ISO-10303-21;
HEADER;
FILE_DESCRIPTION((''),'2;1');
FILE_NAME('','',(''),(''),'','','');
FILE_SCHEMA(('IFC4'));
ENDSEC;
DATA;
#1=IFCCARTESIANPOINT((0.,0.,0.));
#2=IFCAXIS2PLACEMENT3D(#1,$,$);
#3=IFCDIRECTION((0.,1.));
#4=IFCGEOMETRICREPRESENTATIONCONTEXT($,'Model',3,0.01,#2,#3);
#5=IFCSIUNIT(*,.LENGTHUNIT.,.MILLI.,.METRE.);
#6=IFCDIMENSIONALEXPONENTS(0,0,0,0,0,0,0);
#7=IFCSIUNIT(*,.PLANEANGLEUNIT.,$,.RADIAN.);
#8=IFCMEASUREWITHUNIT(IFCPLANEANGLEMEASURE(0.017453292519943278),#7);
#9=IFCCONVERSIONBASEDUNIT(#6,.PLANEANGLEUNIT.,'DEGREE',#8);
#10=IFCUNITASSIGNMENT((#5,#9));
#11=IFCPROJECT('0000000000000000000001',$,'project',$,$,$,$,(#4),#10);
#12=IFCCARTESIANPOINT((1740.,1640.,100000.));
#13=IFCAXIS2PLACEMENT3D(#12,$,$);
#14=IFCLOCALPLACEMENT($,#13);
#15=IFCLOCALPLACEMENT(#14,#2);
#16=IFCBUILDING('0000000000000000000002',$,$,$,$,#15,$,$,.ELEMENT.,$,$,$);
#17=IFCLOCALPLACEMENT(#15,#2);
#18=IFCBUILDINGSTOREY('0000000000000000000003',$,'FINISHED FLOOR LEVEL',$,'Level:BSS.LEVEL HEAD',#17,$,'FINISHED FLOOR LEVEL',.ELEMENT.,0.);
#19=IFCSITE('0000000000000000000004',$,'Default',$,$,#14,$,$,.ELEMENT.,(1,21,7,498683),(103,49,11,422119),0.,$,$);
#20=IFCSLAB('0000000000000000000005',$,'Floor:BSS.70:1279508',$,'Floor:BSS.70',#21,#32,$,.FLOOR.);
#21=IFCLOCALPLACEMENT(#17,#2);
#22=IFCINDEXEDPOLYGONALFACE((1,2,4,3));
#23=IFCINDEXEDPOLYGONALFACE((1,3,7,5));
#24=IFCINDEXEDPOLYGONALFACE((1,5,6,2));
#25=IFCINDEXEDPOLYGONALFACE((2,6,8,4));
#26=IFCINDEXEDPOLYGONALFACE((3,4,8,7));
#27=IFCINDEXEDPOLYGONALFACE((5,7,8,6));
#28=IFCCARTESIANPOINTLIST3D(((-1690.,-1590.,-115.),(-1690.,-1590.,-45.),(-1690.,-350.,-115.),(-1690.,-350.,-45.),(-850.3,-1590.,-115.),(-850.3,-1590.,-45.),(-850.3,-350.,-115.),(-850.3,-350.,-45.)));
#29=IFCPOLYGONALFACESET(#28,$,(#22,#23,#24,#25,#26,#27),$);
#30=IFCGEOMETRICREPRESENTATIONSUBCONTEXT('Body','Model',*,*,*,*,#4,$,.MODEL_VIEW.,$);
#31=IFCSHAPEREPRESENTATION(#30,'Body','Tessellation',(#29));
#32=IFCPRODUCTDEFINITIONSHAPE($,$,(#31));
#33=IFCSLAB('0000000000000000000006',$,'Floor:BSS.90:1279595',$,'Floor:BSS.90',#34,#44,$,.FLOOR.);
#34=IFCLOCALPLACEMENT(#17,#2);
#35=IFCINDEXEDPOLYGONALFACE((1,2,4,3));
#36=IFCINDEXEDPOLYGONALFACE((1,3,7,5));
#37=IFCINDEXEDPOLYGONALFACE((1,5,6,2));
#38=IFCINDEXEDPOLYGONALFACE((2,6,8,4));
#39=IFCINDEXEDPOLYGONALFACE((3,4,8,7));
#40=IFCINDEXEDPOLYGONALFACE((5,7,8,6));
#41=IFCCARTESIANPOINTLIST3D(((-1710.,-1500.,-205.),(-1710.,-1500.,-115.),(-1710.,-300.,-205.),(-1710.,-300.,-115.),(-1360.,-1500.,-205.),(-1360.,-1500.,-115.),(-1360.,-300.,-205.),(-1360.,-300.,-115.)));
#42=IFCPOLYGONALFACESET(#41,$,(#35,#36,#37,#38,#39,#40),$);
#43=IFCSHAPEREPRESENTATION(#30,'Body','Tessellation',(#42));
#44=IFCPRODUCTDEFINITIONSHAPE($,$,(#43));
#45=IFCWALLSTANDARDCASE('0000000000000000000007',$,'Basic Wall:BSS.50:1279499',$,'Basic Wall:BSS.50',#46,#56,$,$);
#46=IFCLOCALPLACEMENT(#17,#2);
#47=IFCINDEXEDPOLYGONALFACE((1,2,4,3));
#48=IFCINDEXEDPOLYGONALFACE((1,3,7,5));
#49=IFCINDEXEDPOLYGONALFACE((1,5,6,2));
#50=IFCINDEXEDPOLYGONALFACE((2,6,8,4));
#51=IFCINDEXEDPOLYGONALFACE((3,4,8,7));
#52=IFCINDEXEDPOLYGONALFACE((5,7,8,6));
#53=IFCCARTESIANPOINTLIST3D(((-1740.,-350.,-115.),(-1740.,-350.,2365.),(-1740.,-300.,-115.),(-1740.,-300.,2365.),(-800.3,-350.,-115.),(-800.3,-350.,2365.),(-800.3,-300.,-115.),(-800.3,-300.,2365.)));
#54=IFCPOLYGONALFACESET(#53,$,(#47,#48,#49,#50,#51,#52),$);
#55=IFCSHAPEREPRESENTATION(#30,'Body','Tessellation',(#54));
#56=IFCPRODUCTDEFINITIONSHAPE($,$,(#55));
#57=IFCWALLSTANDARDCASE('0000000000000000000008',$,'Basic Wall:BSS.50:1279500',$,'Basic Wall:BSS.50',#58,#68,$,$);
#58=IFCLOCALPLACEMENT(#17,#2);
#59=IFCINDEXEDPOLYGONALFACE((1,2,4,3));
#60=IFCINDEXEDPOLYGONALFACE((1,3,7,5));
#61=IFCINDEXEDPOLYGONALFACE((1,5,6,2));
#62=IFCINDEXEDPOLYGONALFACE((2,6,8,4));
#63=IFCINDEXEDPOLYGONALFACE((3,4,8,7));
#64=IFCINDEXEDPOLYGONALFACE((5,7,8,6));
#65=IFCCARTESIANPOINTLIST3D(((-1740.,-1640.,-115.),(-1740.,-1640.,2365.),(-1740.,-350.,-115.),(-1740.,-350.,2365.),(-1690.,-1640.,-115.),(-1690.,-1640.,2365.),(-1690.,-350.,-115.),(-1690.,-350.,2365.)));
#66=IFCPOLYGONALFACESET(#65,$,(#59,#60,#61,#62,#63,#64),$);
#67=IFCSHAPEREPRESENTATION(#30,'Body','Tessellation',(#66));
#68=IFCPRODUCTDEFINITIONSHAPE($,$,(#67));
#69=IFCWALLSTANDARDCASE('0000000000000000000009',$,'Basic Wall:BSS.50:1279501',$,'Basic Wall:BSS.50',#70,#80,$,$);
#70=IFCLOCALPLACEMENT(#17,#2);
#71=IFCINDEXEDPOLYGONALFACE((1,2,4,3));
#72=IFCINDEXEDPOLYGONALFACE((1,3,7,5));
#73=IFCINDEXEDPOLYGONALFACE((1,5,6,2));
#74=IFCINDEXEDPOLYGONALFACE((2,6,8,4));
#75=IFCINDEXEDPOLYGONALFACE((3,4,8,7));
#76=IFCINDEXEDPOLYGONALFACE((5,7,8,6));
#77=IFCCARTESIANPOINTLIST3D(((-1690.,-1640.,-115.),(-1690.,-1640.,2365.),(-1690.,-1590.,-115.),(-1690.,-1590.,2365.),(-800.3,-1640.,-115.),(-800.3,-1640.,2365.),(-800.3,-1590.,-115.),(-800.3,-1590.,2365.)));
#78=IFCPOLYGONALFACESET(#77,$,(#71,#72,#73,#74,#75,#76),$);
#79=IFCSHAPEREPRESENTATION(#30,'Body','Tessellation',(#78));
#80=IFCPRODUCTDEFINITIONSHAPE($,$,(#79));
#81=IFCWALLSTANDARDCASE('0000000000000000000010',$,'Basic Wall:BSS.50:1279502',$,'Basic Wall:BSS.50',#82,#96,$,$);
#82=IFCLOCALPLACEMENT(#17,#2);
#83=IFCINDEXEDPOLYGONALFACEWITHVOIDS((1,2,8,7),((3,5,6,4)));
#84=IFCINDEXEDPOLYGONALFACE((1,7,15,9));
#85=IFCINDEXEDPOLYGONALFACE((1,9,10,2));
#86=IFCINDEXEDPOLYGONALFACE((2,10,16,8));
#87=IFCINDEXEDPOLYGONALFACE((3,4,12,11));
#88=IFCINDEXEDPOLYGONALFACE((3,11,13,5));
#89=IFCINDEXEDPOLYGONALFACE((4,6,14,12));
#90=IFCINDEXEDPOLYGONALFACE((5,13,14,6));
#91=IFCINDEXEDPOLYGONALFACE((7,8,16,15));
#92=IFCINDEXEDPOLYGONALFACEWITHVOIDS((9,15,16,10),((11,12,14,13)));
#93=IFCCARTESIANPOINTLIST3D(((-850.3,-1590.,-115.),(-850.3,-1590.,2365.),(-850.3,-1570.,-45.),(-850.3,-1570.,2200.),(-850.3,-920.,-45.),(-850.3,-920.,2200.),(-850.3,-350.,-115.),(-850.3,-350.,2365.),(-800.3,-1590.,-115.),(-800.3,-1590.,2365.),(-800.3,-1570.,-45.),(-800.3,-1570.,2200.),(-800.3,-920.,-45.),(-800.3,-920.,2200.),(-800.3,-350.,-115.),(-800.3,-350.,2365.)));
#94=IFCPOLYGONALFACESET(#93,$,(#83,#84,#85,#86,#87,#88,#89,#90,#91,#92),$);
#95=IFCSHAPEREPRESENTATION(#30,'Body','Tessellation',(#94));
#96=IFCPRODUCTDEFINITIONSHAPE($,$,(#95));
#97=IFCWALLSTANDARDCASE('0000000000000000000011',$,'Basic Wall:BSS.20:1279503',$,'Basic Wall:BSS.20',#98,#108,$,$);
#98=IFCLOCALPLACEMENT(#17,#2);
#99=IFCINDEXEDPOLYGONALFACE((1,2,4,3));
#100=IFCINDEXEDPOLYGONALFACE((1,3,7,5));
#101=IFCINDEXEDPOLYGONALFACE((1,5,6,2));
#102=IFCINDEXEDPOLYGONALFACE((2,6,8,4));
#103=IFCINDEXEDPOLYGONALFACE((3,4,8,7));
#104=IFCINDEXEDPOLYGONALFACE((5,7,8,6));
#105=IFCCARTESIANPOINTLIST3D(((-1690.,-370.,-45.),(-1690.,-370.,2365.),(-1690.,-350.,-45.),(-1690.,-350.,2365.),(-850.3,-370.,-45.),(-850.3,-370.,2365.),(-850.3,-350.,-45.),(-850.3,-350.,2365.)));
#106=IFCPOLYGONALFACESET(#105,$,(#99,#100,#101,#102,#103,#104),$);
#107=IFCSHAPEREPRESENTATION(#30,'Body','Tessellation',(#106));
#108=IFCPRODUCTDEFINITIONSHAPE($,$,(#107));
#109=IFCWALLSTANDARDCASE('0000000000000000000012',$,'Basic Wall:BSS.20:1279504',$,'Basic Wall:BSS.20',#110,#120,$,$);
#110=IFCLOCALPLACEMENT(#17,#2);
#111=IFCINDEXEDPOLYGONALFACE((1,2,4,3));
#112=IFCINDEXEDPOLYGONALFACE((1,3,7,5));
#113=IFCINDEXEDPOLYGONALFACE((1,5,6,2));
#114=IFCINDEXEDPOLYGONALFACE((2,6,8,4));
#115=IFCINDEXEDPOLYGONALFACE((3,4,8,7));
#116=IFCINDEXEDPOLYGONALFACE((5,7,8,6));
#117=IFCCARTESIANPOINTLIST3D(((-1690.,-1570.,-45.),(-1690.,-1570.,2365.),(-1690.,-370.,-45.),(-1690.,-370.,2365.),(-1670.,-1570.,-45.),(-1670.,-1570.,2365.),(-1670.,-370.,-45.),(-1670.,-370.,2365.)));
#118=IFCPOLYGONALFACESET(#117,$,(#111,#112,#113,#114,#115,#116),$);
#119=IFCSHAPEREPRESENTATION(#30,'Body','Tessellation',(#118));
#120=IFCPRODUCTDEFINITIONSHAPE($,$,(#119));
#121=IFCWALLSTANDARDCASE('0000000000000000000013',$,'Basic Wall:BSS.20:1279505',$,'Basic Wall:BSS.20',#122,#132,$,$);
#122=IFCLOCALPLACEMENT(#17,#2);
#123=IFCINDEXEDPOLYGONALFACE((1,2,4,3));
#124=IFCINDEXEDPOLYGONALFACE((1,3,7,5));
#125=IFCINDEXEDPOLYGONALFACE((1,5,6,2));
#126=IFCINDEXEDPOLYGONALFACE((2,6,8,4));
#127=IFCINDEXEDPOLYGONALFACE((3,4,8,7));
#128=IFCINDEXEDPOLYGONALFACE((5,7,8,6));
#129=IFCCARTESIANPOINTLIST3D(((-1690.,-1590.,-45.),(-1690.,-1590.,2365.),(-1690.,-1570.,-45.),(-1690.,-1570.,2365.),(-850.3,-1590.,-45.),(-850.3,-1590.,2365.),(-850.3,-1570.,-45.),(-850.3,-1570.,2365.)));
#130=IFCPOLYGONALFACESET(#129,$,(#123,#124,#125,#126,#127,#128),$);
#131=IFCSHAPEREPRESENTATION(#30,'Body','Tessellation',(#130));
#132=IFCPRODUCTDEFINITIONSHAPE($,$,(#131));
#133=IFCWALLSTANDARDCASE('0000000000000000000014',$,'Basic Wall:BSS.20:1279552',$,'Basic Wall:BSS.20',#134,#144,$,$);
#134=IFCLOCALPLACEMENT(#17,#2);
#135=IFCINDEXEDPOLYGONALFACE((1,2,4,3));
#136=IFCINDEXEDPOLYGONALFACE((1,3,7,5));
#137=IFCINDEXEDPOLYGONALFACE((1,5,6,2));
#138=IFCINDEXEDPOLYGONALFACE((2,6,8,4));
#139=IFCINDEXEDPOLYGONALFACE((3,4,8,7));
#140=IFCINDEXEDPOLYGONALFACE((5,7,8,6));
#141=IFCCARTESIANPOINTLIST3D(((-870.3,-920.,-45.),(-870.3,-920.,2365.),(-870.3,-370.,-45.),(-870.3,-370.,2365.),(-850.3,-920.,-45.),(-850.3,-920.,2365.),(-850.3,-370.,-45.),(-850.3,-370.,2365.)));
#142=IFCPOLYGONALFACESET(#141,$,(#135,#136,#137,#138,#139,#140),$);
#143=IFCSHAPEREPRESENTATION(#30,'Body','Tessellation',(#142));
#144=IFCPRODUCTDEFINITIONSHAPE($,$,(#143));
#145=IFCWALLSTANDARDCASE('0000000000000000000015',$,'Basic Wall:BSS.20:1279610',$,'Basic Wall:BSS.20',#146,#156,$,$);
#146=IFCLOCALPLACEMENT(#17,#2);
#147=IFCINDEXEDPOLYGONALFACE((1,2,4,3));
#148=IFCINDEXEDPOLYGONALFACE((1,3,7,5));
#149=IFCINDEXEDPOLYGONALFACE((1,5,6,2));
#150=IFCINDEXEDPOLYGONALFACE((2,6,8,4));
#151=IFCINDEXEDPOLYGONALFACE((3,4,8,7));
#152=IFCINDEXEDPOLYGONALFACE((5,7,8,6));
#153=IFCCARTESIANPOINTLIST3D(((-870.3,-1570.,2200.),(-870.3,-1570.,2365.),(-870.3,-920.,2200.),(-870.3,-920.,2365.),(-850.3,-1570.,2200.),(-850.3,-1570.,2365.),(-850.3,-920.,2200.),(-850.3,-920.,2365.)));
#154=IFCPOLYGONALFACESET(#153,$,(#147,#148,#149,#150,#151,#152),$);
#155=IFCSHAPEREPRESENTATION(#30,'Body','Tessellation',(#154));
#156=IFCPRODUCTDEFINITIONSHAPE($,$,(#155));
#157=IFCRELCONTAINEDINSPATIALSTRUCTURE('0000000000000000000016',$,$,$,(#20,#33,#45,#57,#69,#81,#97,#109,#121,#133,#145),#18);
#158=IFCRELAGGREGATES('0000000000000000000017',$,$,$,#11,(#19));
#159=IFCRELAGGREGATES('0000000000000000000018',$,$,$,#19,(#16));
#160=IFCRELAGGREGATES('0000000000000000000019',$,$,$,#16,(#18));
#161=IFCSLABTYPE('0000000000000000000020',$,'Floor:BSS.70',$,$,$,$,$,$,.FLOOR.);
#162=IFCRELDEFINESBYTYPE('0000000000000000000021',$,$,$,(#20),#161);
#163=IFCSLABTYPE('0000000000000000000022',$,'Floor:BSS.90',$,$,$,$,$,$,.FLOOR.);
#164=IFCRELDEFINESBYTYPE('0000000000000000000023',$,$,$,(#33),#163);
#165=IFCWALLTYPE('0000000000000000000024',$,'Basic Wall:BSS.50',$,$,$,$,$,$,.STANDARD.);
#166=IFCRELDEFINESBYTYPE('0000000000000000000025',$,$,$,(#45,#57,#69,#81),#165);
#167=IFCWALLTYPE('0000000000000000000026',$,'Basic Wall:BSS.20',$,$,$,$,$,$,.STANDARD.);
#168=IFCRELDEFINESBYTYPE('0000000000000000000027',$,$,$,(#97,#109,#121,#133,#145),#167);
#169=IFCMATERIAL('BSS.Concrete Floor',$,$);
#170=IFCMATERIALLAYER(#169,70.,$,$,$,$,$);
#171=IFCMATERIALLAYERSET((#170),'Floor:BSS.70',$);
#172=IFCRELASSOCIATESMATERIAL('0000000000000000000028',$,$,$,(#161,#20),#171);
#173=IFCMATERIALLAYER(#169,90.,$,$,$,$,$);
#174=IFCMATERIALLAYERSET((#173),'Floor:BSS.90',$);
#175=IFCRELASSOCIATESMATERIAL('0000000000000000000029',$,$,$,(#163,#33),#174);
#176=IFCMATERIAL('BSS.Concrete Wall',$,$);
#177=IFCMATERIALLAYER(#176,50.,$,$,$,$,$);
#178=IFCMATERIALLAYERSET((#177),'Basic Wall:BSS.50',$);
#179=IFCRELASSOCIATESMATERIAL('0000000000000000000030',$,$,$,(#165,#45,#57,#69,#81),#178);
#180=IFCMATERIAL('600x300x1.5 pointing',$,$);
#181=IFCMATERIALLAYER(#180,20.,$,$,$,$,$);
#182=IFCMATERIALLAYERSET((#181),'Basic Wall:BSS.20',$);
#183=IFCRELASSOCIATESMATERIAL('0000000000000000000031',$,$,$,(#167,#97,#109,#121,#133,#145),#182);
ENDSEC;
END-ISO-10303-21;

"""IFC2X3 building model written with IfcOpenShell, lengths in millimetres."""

from ifc_helpers import new_model, entity, si_unit, converted_unit, direction, frame, frame_2d, origin, place, context, subcontext, project, spatial, polyline, rectangle, extrude, clip, halfspace, bounded_halfspace, material, layer, layer_set, layer_usage, type_object, element, save


model = new_model("IFC2X3")

# Units and contexts
model_context = context("Model", 3, precision=0.01, world=origin(), true_north=direction((0.0, 1.0)))
body_context = subcontext(model_context, "Body", "Model", "MODEL_VIEW")
ifc_project = project(units=[si_unit("LENGTHUNIT", "METRE", prefix="MILLI"), converted_unit("PLANEANGLEUNIT", "DEGREE", entity("IfcPlaneAngleMeasure", 0.017453292519943278), si_unit("PLANEANGLEUNIT", "RADIAN"), dimensions=[0, 0, 0, 0, 0, 0, 0])], contexts=[model_context])

# Site, building, storey
site_placement = place(None, frame((1740.0, 1640.0, 100000.0)))
site = spatial("IfcSite", under=ifc_project, at=site_placement, Name="Default", CompositionType="ELEMENT", RefLatitude=(1, 21, 7, 498683), RefLongitude=(103, 49, 11, 422119), RefElevation=0.0)
building_placement = place(site_placement, origin())
building = spatial("IfcBuilding", under=site, at=building_placement, CompositionType="ELEMENT")
storey_placement = place(building_placement, origin())
storey = spatial("IfcBuildingStorey", under=building, at=storey_placement, Name="FINISHED FLOOR LEVEL", ObjectType="Level:BSS.LEVEL HEAD", LongName="FINISHED FLOOR LEVEL", CompositionType="ELEMENT", Elevation=0.0)

# Slabs
ifc_material_1 = material(Name="BSS.Concrete Floor")
ifc_layer_1 = layer(ifc_material_1, 70.0)
ifc_layer_set_1 = layer_set([ifc_layer_1], Name="Floor:BSS.70")
ifc_layer_usage_1 = layer_usage(ifc_layer_set_1, "AXIS3", "POSITIVE", 0.0)
slab_type_1 = type_object("IfcSlabType", Name="Floor:BSS.70", PredefinedType="FLOOR", material=ifc_layer_set_1)
slab_1_placement = place(storey_placement, origin())
element("IfcSlab", 1, at=slab_1_placement, inside=storey, type_object=slab_type_1, material=ifc_layer_usage_1, Name="Floor:BSS.70:1279508", ObjectType="Floor:BSS.70", PredefinedType="FLOOR", context=body_context, shape_type="SweptSolid", body=[
    extrude(rectangle(XDim=1240.0, YDim=839.7, at=frame_2d((0.0, 0.0), x_axis=(1.0, 0.0))), frame((-1270.1, -970.0, -45.0), z_axis=(0.0, 0.0, -1.0), x_axis=(0.0, 1.0, 0.0)), (0.0, 0.0, 1.0), 70.0),
])
ifc_material_2 = material(Name="600x300x1.5 pointing")
ifc_layer_2 = layer(ifc_material_1, 90.0)
ifc_layer_set_2 = layer_set([ifc_layer_2], Name="Floor:BSS.90")
ifc_layer_usage_2 = layer_usage(ifc_layer_set_2, "AXIS3", "POSITIVE", 0.0)
slab_type_2 = type_object("IfcSlabType", Name="Floor:BSS.90", PredefinedType="FLOOR", material=ifc_layer_set_2)
slab_2_placement = place(storey_placement, origin())
element("IfcSlab", 2, at=slab_2_placement, inside=storey, type_object=slab_type_2, material=ifc_layer_usage_2, Name="Floor:BSS.90:1279595", ObjectType="Floor:BSS.90", PredefinedType="FLOOR", context=body_context, shape_type="SweptSolid", body=[
    extrude(rectangle(XDim=1200.0, YDim=350.0, at=frame_2d((0.0, 0.0), x_axis=(1.0, 0.0))), frame((-1535.0, -900.0, -115.0), z_axis=(0.0, 0.0, -1.0), x_axis=(0.0, 1.0, 0.0)), (0.0, 0.0, 1.0), 90.0),
])

# Walls
ifc_material_3 = material(Name="BSS.Concrete Wall")
ifc_layer_3 = layer(ifc_material_3, 50.0)
ifc_layer_set_3 = layer_set([ifc_layer_3], Name="Basic Wall:BSS.50")
ifc_layer_usage_3 = layer_usage(ifc_layer_set_3, "AXIS2", "POSITIVE", -25.0)
wall_type_1 = type_object("IfcWallType", Name="Basic Wall:BSS.50", PredefinedType="STANDARD", material=ifc_layer_set_3)
wall_1_placement = place(storey_placement, frame((-800.3, -325.0, -115.0), z_axis=(0.0, 0.0, 1.0), x_axis=(-1.0, 0.0, 0.0)))
element("IfcWallStandardCase", 3, at=wall_1_placement, inside=storey, type_object=wall_type_1, material=ifc_layer_usage_3, Name="Basic Wall:BSS.50:1279499", ObjectType="Basic Wall:BSS.50", context=body_context, shape_type="Clipping", body=[
    clip(extrude(rectangle(XDim=939.7, YDim=50.0, at=frame_2d((469.9, 0.0), x_axis=(-1.0, 0.0))), origin(), (0.0, 0.0, 1.0), 2480.0), bounded_halfspace(frame((0.0, -25.0, 2480.0), z_axis=(0.0, 0.0, -1.0), x_axis=(0.0, 1.0, 0.0)), True, frame((0.0, -25.0, 2480.0)), polyline([(0.0, 0.0), (939.7, 0.0), (939.7, 50.0), (889.7, 50.0), (50.0, 50.0), (0.0, 50.0), (0.0, 0.0)]))),
])
ifc_layer_usage_4 = layer_usage(ifc_layer_set_3, "AXIS2", "NEGATIVE", 25.0)
wall_2_placement = place(storey_placement, frame((-1715.0, -350.0, -115.0), z_axis=(0.0, 0.0, 1.0), x_axis=(0.0, -1.0, 0.0)))
element("IfcWallStandardCase", 4, at=wall_2_placement, inside=storey, type_object=wall_type_1, material=ifc_layer_usage_4, Name="Basic Wall:BSS.50:1279500", ObjectType="Basic Wall:BSS.50", context=body_context, shape_type="Clipping", body=[
    clip(extrude(rectangle(XDim=1290.0, YDim=50.0, at=frame_2d((645.0, 0.0), x_axis=(-1.0, 0.0))), origin(), (0.0, 0.0, 1.0), 2480.0), bounded_halfspace(frame((0.0, -25.0, 2480.0), z_axis=(0.0, 0.0, -1.0), x_axis=(1.0, 0.0, 0.0)), True, frame((0.0, -25.0, 2480.0)), polyline([(0.0, 0.0), (1290.0, 0.0), (1290.0, 50.0), (1240.0, 50.0), (0.0, 50.0), (0.0, 0.0)]))),
])
ifc_layer_usage_5 = layer_usage(ifc_layer_set_3, "AXIS2", "NEGATIVE", 25.0)
wall_3_placement = place(storey_placement, frame((-1690.0, -1615.0, -115.0)))
element("IfcWallStandardCase", 5, at=wall_3_placement, inside=storey, type_object=wall_type_1, material=ifc_layer_usage_5, Name="Basic Wall:BSS.50:1279501", ObjectType="Basic Wall:BSS.50", context=body_context, shape_type="Clipping", body=[
    clip(extrude(rectangle(XDim=889.7, YDim=50.0, at=frame_2d((444.9, 0.0), x_axis=(-1.0, 0.0))), origin(), (0.0, 0.0, 1.0), 2480.0), bounded_halfspace(frame((0.0, -25.0, 2480.0), z_axis=(0.0, 0.0, -1.0), x_axis=(0.0, -1.0, 0.0)), True, frame((0.0, -25.0, 2480.0)), polyline([(0.0, 0.0), (889.7, 0.0), (889.7, 50.0), (839.7, 50.0), (0.0, 50.0), (0.0, 0.0)]))),
])

# Wall, opening
ifc_layer_usage_6 = layer_usage(ifc_layer_set_3, "AXIS2", "POSITIVE", -25.0)
wall_4_placement = place(storey_placement, frame((-825.3, -1590.0, -115.0), z_axis=(0.0, 0.0, 1.0), x_axis=(0.0, 1.0, 0.0)))
wall_4 = element("IfcWallStandardCase", 6, at=wall_4_placement, inside=storey, type_object=wall_type_1, material=ifc_layer_usage_6, Name="Basic Wall:BSS.50:1279502", ObjectType="Basic Wall:BSS.50", context=body_context, shape_type="Clipping", body=[
    clip(extrude(rectangle(XDim=1240.0, YDim=50.0, at=frame_2d((620.0, 0.0), x_axis=(-1.0, 0.0))), origin(), (0.0, 0.0, 1.0), 2480.0), bounded_halfspace(frame((0.0, -25.0, 2480.0), z_axis=(0.0, 0.0, -1.0), x_axis=(-1.0, 0.0, 0.0)), True, frame((0.0, -25.0, 2480.0)), polyline([(0.0, 0.0), (1240.0, 0.0), (1240.0, 50.0), (1220.0, 50.0), (0.0, 50.0), (0.0, 0.0)]))),
])
opening_placement = place(wall_4_placement, frame((1590.0, -825.3, 115.0), z_axis=(0.0, 0.0, 1.0), x_axis=(0.0, -1.0, 0.0)))
element("IfcOpeningElement", 7, at=opening_placement, cuts=wall_4, ObjectType="Opening", context=body_context, shape_type="SweptSolid", body=[
    extrude(rectangle(XDim=2245.0, YDim=650.0, at=frame_2d((0.0, 0.0), x_axis=(0.0, 1.0))), frame((673.7, -1245.0, 1077.5), z_axis=(-1.0, 0.0, 0.0), x_axis=(0.0, 1.0, 0.0)), (0.0, 0.0, 1.0), 3048.0),
])

# Walls
ifc_layer_4 = layer(ifc_material_2, 20.0)
ifc_layer_set_4 = layer_set([ifc_layer_4], Name="Basic Wall:BSS.20")
ifc_layer_usage_7 = layer_usage(ifc_layer_set_4, "AXIS2", "POSITIVE", -10.0)
wall_type_2 = type_object("IfcWallType", Name="Basic Wall:BSS.20", PredefinedType="STANDARD", material=ifc_layer_set_4)
wall_5_placement = place(storey_placement, frame((-850.3, -360.0, -45.0), z_axis=(0.0, 0.0, 1.0), x_axis=(-1.0, 0.0, 0.0)))
element("IfcWallStandardCase", 8, at=wall_5_placement, inside=storey, type_object=wall_type_2, material=ifc_layer_usage_7, Name="Basic Wall:BSS.20:1279503", ObjectType="Basic Wall:BSS.20", context=body_context, shape_type="SweptSolid", body=[
    extrude(rectangle(XDim=839.7, YDim=20.0, at=frame_2d((419.9, 0.0), x_axis=(-1.0, 0.0))), origin(), (0.0, 0.0, 1.0), 2410.0),
])
ifc_layer_usage_8 = layer_usage(ifc_layer_set_4, "AXIS2", "NEGATIVE", 10.0)
wall_6_placement = place(storey_placement, frame((-1680.0, -1570.0, -45.0), z_axis=(0.0, 0.0, 1.0), x_axis=(0.0, 1.0, 0.0)))
element("IfcWallStandardCase", 9, at=wall_6_placement, inside=storey, type_object=wall_type_2, material=ifc_layer_usage_8, Name="Basic Wall:BSS.20:1279504", ObjectType="Basic Wall:BSS.20", context=body_context, shape_type="SweptSolid", body=[
    extrude(rectangle(XDim=1200.0, YDim=20.0, at=frame_2d((600.0, 0.0), x_axis=(-1.0, 0.0))), origin(), (0.0, 0.0, 1.0), 2410.0),
])
ifc_layer_usage_9 = layer_usage(ifc_layer_set_4, "AXIS2", "POSITIVE", -10.0)
wall_7_placement = place(storey_placement, frame((-1690.0, -1580.0, -45.0)))
element("IfcWallStandardCase", 10, at=wall_7_placement, inside=storey, type_object=wall_type_2, material=ifc_layer_usage_9, Name="Basic Wall:BSS.20:1279505", ObjectType="Basic Wall:BSS.20", context=body_context, shape_type="SweptSolid", body=[
    extrude(rectangle(XDim=839.7, YDim=20.0, at=frame_2d((419.9, 0.0), x_axis=(-1.0, 0.0))), origin(), (0.0, 0.0, 1.0), 2410.0),
])
ifc_layer_usage_10 = layer_usage(ifc_layer_set_4, "AXIS2", "POSITIVE", -10.0)
wall_8_placement = place(storey_placement, frame((-860.3, -920.0, -45.0), z_axis=(0.0, 0.0, 1.0), x_axis=(0.0, 1.0, 0.0)))
element("IfcWallStandardCase", 11, at=wall_8_placement, inside=storey, type_object=wall_type_2, material=ifc_layer_usage_10, Name="Basic Wall:BSS.20:1279552", ObjectType="Basic Wall:BSS.20", context=body_context, shape_type="SweptSolid", body=[
    extrude(rectangle(XDim=550.0, YDim=20.0, at=frame_2d((275.0, 0.0), x_axis=(-1.0, 0.0))), origin(), (0.0, 0.0, 1.0), 2410.0),
])
ifc_layer_usage_11 = layer_usage(ifc_layer_set_4, "AXIS2", "POSITIVE", -10.0)
wall_9_placement = place(storey_placement, frame((-860.3, -1570.0, 2200.0), z_axis=(0.0, 0.0, 1.0), x_axis=(0.0, 1.0, 0.0)))
element("IfcWallStandardCase", 12, at=wall_9_placement, inside=storey, type_object=wall_type_2, material=ifc_layer_usage_11, Name="Basic Wall:BSS.20:1279610", ObjectType="Basic Wall:BSS.20", context=body_context, shape_type="Clipping", body=[
    clip(extrude(rectangle(XDim=650.0, YDim=20.0, at=frame_2d((325.0, 0.0), x_axis=(-1.0, 0.0))), origin(), (0.0, 0.0, 1.0), 165.0), halfspace(frame((650.0, -10.0, 0.0), z_axis=(0.0, 0.0, -1.0), x_axis=(0.0, 1.0, 0.0)), False)),
])

save(model, "model.ifc")
